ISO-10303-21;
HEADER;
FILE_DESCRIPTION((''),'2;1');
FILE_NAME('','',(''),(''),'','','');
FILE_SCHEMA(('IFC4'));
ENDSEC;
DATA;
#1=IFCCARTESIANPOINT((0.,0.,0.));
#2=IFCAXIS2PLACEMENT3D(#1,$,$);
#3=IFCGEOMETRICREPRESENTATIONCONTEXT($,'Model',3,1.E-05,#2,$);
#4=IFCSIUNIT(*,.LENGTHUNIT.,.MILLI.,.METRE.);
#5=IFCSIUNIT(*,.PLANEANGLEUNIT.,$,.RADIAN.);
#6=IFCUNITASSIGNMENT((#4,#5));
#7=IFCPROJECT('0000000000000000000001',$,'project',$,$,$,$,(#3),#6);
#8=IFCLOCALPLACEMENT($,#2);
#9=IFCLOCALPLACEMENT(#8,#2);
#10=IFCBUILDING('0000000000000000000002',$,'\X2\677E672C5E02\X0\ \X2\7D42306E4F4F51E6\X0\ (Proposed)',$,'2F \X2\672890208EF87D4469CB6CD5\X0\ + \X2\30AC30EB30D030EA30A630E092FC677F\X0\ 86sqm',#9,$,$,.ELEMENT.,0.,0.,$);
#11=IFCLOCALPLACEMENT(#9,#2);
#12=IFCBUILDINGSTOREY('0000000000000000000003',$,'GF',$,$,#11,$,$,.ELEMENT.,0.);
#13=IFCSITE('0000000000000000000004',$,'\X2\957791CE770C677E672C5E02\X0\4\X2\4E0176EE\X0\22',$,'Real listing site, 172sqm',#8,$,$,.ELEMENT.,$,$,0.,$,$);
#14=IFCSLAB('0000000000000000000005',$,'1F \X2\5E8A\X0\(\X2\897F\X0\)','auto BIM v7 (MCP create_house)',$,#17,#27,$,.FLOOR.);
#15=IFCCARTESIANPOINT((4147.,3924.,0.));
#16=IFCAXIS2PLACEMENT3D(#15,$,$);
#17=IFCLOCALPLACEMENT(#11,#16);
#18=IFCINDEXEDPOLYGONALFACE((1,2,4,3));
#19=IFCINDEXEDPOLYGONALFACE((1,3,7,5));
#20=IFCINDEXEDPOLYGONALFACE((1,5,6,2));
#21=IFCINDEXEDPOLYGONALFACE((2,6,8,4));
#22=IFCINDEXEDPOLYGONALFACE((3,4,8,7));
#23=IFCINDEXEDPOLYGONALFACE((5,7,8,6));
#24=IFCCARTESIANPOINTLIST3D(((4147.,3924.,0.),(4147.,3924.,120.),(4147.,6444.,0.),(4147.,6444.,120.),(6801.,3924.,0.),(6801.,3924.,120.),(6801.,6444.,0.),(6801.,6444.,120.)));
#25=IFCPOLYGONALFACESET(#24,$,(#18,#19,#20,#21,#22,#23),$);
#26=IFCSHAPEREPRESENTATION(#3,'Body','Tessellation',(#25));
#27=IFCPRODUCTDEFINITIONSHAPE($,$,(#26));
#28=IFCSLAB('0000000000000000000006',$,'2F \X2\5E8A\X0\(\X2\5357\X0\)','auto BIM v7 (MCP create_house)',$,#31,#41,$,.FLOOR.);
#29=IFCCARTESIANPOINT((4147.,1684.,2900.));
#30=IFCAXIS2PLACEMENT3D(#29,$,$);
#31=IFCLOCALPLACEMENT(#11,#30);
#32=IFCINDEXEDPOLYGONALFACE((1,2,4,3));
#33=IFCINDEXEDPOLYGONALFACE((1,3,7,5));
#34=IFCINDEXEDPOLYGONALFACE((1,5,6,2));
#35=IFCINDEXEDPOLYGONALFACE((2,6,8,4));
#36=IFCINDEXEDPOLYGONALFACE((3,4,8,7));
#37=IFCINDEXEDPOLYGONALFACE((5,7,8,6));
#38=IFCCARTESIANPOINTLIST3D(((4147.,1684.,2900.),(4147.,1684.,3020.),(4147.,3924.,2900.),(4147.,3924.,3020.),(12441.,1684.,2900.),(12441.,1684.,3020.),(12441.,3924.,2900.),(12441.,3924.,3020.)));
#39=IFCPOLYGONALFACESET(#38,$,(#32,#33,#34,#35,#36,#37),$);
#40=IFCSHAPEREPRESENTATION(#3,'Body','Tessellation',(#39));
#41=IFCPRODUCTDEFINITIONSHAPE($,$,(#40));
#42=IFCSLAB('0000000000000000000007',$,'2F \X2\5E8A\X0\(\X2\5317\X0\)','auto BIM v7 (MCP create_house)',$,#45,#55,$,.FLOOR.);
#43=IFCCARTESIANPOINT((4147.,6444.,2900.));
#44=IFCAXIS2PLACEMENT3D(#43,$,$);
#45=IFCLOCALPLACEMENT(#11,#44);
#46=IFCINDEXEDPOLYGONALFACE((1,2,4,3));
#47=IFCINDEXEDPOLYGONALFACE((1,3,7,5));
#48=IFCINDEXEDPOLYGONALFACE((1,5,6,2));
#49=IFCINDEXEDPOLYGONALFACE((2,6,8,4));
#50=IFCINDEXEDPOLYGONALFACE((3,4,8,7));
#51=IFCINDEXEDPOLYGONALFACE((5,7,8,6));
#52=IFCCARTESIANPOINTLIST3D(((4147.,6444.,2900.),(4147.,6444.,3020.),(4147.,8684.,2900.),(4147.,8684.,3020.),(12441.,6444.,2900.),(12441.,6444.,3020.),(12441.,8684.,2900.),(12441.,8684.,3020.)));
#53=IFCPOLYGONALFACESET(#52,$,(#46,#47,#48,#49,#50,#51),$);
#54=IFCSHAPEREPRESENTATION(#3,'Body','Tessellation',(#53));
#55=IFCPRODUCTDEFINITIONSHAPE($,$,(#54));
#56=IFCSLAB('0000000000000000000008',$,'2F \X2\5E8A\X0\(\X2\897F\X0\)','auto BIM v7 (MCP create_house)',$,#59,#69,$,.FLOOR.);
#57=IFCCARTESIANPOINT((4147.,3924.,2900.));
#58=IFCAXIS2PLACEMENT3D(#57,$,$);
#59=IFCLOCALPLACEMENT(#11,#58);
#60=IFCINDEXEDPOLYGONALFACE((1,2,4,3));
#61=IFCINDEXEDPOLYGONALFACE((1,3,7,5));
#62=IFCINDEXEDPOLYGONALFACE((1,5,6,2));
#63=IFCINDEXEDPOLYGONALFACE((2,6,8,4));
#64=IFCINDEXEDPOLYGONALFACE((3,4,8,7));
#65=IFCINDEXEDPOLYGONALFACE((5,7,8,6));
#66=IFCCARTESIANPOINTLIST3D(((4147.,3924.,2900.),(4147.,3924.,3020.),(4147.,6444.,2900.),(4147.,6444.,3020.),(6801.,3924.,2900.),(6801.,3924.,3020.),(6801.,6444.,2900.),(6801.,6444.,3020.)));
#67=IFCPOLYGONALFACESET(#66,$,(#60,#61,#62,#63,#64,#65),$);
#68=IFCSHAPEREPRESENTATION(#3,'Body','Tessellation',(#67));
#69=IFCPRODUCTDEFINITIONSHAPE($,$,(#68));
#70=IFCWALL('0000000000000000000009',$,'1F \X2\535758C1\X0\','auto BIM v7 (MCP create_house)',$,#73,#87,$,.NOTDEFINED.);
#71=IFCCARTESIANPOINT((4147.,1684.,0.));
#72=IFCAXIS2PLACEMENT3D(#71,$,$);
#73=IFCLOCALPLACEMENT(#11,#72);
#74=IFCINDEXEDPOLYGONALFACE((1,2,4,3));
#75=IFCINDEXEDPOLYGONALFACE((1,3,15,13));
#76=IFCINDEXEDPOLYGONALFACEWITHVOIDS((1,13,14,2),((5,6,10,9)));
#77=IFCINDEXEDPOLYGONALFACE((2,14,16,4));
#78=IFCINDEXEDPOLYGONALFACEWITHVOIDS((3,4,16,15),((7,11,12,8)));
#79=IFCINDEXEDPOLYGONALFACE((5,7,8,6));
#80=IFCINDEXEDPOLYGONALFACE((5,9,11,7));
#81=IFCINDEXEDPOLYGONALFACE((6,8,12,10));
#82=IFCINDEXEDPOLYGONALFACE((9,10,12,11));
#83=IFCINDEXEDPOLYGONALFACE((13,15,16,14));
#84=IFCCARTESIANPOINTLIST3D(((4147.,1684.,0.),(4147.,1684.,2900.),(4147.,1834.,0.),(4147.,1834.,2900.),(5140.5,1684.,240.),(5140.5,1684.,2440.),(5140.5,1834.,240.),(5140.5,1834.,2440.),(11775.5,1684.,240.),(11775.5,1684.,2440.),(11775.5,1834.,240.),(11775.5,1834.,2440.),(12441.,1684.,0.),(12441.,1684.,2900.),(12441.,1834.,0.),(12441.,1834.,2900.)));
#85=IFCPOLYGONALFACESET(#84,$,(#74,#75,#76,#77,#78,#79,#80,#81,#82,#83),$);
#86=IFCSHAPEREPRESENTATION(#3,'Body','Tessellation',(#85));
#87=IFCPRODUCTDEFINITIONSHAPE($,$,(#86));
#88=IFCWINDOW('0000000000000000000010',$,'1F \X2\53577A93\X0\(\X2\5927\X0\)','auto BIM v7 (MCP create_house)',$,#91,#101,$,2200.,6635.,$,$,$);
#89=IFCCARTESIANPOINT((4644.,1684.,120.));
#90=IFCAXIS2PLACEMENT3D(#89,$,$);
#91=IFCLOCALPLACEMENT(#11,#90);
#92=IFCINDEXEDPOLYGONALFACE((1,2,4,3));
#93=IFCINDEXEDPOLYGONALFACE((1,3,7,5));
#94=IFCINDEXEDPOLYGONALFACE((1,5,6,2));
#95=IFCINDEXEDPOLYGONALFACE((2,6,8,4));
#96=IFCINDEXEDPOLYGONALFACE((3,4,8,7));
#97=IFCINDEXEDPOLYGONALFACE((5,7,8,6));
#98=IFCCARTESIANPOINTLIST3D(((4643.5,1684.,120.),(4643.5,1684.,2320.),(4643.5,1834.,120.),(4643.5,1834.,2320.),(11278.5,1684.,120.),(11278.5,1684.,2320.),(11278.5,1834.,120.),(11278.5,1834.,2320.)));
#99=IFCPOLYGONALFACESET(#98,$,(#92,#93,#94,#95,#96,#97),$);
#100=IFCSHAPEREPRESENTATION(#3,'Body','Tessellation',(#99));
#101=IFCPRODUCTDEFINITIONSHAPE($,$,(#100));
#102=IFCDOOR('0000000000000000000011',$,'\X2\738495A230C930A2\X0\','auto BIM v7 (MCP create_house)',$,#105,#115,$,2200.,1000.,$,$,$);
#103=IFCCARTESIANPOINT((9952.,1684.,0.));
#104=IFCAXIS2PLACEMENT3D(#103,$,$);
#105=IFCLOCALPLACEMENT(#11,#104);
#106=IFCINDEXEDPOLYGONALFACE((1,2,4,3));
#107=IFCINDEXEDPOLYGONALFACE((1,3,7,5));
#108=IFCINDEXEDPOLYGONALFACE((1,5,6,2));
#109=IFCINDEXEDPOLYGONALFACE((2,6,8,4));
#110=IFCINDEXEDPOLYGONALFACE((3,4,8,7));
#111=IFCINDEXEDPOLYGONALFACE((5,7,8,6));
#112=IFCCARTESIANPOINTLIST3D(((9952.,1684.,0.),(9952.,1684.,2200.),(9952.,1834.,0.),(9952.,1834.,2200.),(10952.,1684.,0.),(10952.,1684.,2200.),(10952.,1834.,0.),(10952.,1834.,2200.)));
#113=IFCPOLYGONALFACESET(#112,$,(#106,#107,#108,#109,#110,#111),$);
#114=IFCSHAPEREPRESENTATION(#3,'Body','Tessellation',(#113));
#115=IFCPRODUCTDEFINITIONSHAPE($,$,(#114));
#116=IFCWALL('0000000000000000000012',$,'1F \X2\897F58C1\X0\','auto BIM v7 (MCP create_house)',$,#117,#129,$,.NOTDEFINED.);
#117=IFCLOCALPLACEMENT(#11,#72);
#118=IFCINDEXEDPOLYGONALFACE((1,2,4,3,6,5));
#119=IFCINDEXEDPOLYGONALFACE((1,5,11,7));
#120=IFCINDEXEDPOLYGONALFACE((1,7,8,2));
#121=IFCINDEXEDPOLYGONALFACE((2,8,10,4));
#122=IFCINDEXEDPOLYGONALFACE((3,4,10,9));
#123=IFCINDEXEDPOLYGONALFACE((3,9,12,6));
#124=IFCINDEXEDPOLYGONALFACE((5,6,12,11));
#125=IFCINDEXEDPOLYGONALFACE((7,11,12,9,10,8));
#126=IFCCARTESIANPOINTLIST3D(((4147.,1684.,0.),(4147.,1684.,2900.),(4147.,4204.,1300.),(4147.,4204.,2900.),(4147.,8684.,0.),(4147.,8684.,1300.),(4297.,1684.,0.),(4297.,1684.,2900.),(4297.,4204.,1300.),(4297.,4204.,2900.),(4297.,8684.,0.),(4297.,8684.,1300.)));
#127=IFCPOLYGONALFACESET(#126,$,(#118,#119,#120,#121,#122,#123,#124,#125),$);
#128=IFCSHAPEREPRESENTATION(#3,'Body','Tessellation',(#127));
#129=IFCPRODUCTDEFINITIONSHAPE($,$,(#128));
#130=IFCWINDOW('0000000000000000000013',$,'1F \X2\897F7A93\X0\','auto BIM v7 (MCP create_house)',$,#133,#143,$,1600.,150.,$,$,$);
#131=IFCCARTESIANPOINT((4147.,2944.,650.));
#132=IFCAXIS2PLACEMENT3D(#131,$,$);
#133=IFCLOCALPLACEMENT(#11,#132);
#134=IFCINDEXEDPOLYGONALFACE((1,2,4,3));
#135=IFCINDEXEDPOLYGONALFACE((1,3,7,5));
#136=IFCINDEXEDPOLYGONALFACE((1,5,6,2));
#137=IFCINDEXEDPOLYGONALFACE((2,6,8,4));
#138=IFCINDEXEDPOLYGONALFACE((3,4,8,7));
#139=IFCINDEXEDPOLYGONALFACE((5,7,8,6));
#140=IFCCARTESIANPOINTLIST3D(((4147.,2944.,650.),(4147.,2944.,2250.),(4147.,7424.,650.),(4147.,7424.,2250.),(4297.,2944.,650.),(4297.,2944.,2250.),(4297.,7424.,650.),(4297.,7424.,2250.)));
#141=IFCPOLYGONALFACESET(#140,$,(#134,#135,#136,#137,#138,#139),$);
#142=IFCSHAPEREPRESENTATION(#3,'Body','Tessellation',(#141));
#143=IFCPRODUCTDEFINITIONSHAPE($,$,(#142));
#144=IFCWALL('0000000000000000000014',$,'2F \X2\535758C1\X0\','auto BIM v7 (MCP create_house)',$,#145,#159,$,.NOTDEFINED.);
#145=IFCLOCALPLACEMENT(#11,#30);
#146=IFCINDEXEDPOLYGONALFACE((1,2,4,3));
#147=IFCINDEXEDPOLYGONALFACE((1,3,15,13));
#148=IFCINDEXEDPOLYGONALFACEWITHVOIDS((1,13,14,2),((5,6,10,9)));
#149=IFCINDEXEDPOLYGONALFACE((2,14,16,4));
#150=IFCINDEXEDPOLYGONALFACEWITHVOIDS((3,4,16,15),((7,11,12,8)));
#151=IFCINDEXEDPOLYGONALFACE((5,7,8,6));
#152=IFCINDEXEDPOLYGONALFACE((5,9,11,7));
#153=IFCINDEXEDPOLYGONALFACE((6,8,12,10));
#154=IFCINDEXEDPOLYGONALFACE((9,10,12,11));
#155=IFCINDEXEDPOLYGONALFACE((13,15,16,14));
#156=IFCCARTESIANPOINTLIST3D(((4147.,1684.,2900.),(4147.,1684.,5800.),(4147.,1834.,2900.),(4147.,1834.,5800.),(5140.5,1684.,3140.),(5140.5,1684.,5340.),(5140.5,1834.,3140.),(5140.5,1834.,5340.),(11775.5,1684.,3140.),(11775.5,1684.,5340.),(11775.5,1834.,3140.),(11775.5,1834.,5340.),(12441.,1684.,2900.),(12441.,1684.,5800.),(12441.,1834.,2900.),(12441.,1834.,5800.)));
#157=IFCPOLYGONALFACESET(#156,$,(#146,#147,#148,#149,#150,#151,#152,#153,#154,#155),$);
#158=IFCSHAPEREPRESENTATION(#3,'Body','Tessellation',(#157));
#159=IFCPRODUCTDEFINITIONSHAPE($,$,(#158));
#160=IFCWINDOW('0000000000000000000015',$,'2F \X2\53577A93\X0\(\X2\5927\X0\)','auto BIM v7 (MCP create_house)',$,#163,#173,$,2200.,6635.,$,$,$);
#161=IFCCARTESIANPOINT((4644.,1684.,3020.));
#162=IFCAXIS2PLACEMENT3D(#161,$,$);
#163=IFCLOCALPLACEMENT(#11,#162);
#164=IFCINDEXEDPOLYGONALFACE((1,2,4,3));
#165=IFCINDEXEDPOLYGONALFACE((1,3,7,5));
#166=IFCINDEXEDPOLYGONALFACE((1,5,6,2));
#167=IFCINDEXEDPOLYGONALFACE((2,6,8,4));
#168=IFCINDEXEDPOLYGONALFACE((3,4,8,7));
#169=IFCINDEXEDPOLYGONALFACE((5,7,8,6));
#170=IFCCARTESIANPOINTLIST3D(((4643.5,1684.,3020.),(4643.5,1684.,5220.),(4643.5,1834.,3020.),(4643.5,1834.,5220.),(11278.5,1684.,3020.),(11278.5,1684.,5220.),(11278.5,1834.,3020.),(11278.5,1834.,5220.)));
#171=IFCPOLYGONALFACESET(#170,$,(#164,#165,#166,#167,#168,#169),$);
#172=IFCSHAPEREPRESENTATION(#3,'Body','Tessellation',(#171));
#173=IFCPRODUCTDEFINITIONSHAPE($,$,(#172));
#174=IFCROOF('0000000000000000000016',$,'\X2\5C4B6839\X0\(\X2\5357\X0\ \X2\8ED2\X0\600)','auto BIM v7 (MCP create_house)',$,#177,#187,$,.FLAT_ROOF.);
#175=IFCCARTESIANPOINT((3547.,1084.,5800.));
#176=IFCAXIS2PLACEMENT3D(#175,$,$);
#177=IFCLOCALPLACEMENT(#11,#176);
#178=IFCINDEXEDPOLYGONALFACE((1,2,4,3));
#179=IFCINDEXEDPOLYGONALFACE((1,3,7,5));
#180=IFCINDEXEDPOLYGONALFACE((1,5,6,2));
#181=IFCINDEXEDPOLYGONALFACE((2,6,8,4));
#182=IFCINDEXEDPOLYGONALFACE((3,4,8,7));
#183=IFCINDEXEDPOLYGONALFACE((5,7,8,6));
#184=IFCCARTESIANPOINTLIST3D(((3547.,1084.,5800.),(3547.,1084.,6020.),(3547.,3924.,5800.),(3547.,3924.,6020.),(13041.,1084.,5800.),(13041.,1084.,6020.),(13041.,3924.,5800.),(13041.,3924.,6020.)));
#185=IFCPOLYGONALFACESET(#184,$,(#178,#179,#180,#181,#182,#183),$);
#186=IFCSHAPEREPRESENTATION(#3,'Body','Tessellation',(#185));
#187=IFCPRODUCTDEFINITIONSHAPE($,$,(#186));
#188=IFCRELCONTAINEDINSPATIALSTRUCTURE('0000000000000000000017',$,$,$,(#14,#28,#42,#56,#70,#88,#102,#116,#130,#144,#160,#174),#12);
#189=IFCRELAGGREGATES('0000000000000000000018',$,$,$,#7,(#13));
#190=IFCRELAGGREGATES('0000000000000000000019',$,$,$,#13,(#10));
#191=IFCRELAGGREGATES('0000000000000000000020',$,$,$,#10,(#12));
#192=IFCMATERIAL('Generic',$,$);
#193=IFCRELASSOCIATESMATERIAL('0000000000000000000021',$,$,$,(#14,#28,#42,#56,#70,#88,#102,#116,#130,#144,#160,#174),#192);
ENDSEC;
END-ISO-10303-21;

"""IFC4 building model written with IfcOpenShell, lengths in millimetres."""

from ifc_helpers import new_model, si_unit, frame, frame_2d, origin, place, context, project, spatial, rectangle, extrude, material, element, fill, save


model = new_model("IFC4")

# Units and contexts
model_context = context("Model", 3, precision=1e-05, world=origin())
ifc_project = project(units=[si_unit("LENGTHUNIT", "METRE", prefix="MILLI"), si_unit("PLANEANGLEUNIT", "RADIAN")], contexts=[model_context])

# Site, building, storey
site_placement = place(None, origin())
site = spatial("IfcSite", under=ifc_project, at=site_placement, Name="長野県松本市4丁目22", ObjectType="Real listing site, 172sqm", CompositionType="ELEMENT", RefElevation=0.0)
building_placement = place(site_placement, origin())
building = spatial("IfcBuilding", under=site, at=building_placement, Name="松本市 終の住処 (Proposed)", ObjectType="2F 木造軸組構法 + ガルバリウム鋼板 86sqm", CompositionType="ELEMENT", ElevationOfRefHeight=0.0, ElevationOfTerrain=0.0)
storey_placement = place(building_placement, origin())
storey = spatial("IfcBuildingStorey", under=building, at=storey_placement, Name="GF", CompositionType="ELEMENT", Elevation=0.0)

# Slabs
ifc_material = material(Name="Generic")
slab_1_placement = place(storey_placement, frame((4147.0, 3924.0, 0.0)))
element("IfcSlab", 1, at=slab_1_placement, inside=storey, material=ifc_material, Name="1F 床(西)", Description="auto BIM v7 (MCP create_house)", PredefinedType="FLOOR", context=model_context, shape_type="SweptSolid", body=[
    extrude(rectangle(XDim=2654.0, YDim=2520.0, at=frame_2d((1327.0, 1260.0))), frame((4147.0, 3924.0, 0.0)), (0.0, 0.0, 1.0), 120.0),
])
slab_2_placement = place(storey_placement, frame((4147.0, 1684.0, 2900.0)))
element("IfcSlab", 2, at=slab_2_placement, inside=storey, material=ifc_material, Name="2F 床(南)", Description="auto BIM v7 (MCP create_house)", PredefinedType="FLOOR", context=model_context, shape_type="SweptSolid", body=[
    extrude(rectangle(XDim=8294.0, YDim=2240.0, at=frame_2d((4147.0, 1120.0))), frame((4147.0, 1684.0, 2900.0)), (0.0, 0.0, 1.0), 120.0),
])
slab_3_placement = place(storey_placement, frame((4147.0, 6444.0, 2900.0)))
element("IfcSlab", 3, at=slab_3_placement, inside=storey, material=ifc_material, Name="2F 床(北)", Description="auto BIM v7 (MCP create_house)", PredefinedType="FLOOR", context=model_context, shape_type="SweptSolid", body=[
    extrude(rectangle(XDim=8294.0, YDim=2240.0, at=frame_2d((4147.0, 1120.0))), frame((4147.0, 6444.0, 2900.0)), (0.0, 0.0, 1.0), 120.0),
])
slab_4_placement = place(storey_placement, frame((4147.0, 3924.0, 2900.0)))
element("IfcSlab", 4, at=slab_4_placement, inside=storey, material=ifc_material, Name="2F 床(西)", Description="auto BIM v7 (MCP create_house)", PredefinedType="FLOOR", context=model_context, shape_type="SweptSolid", body=[
    extrude(rectangle(XDim=2654.0, YDim=2520.0, at=frame_2d((1327.0, 1260.0))), frame((4147.0, 3924.0, 2900.0)), (0.0, 0.0, 1.0), 120.0),
])

# Wall, openings, window, door
wall_1_placement = place(storey_placement, frame((4147.0, 1684.0, 0.0)))
wall_1 = element("IfcWall", 5, at=wall_1_placement, inside=storey, material=ifc_material, Name="1F 南壁", Description="auto BIM v7 (MCP create_house)", PredefinedType="NOTDEFINED", context=model_context, shape_type="SweptSolid", body=[
    extrude(rectangle(XDim=8294.0, YDim=150.0, at=frame_2d((4147.0, 75.0))), frame((4147.0, 1684.0, 0.0)), (0.0, 0.0, 1.0), 2900.0),
])
opening_1_placement = place(storey_placement, frame((4644.0, 1684.0, 120.0)))
opening_1 = element("IfcOpeningElement", 6, at=opening_1_placement, cuts=wall_1, PredefinedType="NOTDEFINED", context=model_context, shape_type="SweptSolid", body=[
    extrude(rectangle(XDim=6635.0, YDim=150.0, at=frame_2d((3317.0, 75.0))), frame((4644.0, 1684.0, 120.0)), (0.0, 0.0, 1.0), 2200.0),
])
opening_2_placement = place(storey_placement, frame((9952.0, 1684.0, 0.0)))
opening_2 = element("IfcOpeningElement", 7, at=opening_2_placement, cuts=wall_1, PredefinedType="NOTDEFINED", context=model_context, shape_type="SweptSolid", body=[
    extrude(rectangle(XDim=1000.0, YDim=150.0, at=frame_2d((500.0, 75.0))), frame((9952.0, 1684.0, 0.0)), (0.0, 0.0, 1.0), 2200.0),
])
window_1_placement = place(storey_placement, frame((4644.0, 1684.0, 120.0)))
window_1 = element("IfcWindow", 8, at=window_1_placement, inside=storey, material=ifc_material, Name="1F 南窓(大)", Description="auto BIM v7 (MCP create_house)", OverallHeight=2200.0, OverallWidth=6635.0, context=model_context, shape_type="SweptSolid", body=[
    extrude(rectangle(XDim=6635.0, YDim=150.0, at=frame_2d((3317.0, 75.0))), frame((4644.0, 1684.0, 120.0)), (0.0, 0.0, 1.0), 2200.0),
])
fill(opening_1, window_1)
door_placement = place(storey_placement, frame((9952.0, 1684.0, 0.0)))
door = element("IfcDoor", 9, at=door_placement, inside=storey, material=ifc_material, Name="玄関ドア", Description="auto BIM v7 (MCP create_house)", OverallHeight=2200.0, OverallWidth=1000.0, context=model_context, shape_type="SweptSolid", body=[
    extrude(rectangle(XDim=1000.0, YDim=150.0, at=frame_2d((500.0, 75.0))), frame((9952.0, 1684.0, 0.0)), (0.0, 0.0, 1.0), 2200.0),
])
fill(opening_2, door)

# Walls, openings, windows
wall_2_placement = place(storey_placement, frame((4147.0, 1684.0, 0.0)))
wall_2 = element("IfcWall", 10, at=wall_2_placement, inside=storey, material=ifc_material, Name="1F 西壁", Description="auto BIM v7 (MCP create_house)", PredefinedType="NOTDEFINED", context=model_context, shape_type="SweptSolid", body=[
    extrude(rectangle(XDim=150.0, YDim=7000.0, at=frame_2d((75.0, 3500.0))), frame((4147.0, 1684.0, 0.0)), (0.0, 0.0, 1.0), 2900.0),
])
opening_3_placement = place(storey_placement, frame((4147.0, 2944.0, 650.0)))
opening_3 = element("IfcOpeningElement", 11, at=opening_3_placement, cuts=wall_2, PredefinedType="NOTDEFINED", context=model_context, shape_type="SweptSolid", body=[
    extrude(rectangle(XDim=150.0, YDim=4480.0, at=frame_2d((75.0, 2240.0))), frame((4147.0, 2944.0, 650.0)), (0.0, 0.0, 1.0), 1600.0),
])
window_2_placement = place(storey_placement, frame((4147.0, 2944.0, 650.0)))
window_2 = element("IfcWindow", 12, at=window_2_placement, inside=storey, material=ifc_material, Name="1F 西窓", Description="auto BIM v7 (MCP create_house)", OverallHeight=1600.0, OverallWidth=150.0, context=model_context, shape_type="SweptSolid", body=[
    extrude(rectangle(XDim=150.0, YDim=4480.0, at=frame_2d((75.0, 2240.0))), frame((4147.0, 2944.0, 650.0)), (0.0, 0.0, 1.0), 1600.0),
])
fill(opening_3, window_2)
wall_3_placement = place(storey_placement, frame((4147.0, 1684.0, 2900.0)))
wall_3 = element("IfcWall", 13, at=wall_3_placement, inside=storey, material=ifc_material, Name="2F 南壁", Description="auto BIM v7 (MCP create_house)", PredefinedType="NOTDEFINED", context=model_context, shape_type="SweptSolid", body=[
    extrude(rectangle(XDim=8294.0, YDim=150.0, at=frame_2d((4147.0, 75.0))), frame((4147.0, 1684.0, 2900.0)), (0.0, 0.0, 1.0), 2900.0),
])
opening_4_placement = place(storey_placement, frame((4644.0, 1684.0, 3020.0)))
opening_4 = element("IfcOpeningElement", 14, at=opening_4_placement, cuts=wall_3, PredefinedType="NOTDEFINED", context=model_context, shape_type="SweptSolid", body=[
    extrude(rectangle(XDim=6635.0, YDim=150.0, at=frame_2d((3317.0, 75.0))), frame((4644.0, 1684.0, 3020.0)), (0.0, 0.0, 1.0), 2200.0),
])
window_3_placement = place(storey_placement, frame((4644.0, 1684.0, 3020.0)))
window_3 = element("IfcWindow", 15, at=window_3_placement, inside=storey, material=ifc_material, Name="2F 南窓(大)", Description="auto BIM v7 (MCP create_house)", OverallHeight=2200.0, OverallWidth=6635.0, context=model_context, shape_type="SweptSolid", body=[
    extrude(rectangle(XDim=6635.0, YDim=150.0, at=frame_2d((3317.0, 75.0))), frame((4644.0, 1684.0, 3020.0)), (0.0, 0.0, 1.0), 2200.0),
])
fill(opening_4, window_3)

# Roof
roof_1_placement = place(storey_placement, frame((3547.0, 1084.0, 5800.0)))
element("IfcRoof", 16, at=roof_1_placement, inside=storey, material=ifc_material, Name="屋根(南 軒600)", Description="auto BIM v7 (MCP create_house)", PredefinedType="FLAT_ROOF", context=model_context, shape_type="SweptSolid", body=[
    extrude(rectangle(XDim=9494.0, YDim=2840.0, at=frame_2d((4747.0, 1420.0))), frame((3547.0, 1084.0, 5800.0)), (0.0, 0.0, 1.0), 220.0),
])

save(model, "model.ifc")
